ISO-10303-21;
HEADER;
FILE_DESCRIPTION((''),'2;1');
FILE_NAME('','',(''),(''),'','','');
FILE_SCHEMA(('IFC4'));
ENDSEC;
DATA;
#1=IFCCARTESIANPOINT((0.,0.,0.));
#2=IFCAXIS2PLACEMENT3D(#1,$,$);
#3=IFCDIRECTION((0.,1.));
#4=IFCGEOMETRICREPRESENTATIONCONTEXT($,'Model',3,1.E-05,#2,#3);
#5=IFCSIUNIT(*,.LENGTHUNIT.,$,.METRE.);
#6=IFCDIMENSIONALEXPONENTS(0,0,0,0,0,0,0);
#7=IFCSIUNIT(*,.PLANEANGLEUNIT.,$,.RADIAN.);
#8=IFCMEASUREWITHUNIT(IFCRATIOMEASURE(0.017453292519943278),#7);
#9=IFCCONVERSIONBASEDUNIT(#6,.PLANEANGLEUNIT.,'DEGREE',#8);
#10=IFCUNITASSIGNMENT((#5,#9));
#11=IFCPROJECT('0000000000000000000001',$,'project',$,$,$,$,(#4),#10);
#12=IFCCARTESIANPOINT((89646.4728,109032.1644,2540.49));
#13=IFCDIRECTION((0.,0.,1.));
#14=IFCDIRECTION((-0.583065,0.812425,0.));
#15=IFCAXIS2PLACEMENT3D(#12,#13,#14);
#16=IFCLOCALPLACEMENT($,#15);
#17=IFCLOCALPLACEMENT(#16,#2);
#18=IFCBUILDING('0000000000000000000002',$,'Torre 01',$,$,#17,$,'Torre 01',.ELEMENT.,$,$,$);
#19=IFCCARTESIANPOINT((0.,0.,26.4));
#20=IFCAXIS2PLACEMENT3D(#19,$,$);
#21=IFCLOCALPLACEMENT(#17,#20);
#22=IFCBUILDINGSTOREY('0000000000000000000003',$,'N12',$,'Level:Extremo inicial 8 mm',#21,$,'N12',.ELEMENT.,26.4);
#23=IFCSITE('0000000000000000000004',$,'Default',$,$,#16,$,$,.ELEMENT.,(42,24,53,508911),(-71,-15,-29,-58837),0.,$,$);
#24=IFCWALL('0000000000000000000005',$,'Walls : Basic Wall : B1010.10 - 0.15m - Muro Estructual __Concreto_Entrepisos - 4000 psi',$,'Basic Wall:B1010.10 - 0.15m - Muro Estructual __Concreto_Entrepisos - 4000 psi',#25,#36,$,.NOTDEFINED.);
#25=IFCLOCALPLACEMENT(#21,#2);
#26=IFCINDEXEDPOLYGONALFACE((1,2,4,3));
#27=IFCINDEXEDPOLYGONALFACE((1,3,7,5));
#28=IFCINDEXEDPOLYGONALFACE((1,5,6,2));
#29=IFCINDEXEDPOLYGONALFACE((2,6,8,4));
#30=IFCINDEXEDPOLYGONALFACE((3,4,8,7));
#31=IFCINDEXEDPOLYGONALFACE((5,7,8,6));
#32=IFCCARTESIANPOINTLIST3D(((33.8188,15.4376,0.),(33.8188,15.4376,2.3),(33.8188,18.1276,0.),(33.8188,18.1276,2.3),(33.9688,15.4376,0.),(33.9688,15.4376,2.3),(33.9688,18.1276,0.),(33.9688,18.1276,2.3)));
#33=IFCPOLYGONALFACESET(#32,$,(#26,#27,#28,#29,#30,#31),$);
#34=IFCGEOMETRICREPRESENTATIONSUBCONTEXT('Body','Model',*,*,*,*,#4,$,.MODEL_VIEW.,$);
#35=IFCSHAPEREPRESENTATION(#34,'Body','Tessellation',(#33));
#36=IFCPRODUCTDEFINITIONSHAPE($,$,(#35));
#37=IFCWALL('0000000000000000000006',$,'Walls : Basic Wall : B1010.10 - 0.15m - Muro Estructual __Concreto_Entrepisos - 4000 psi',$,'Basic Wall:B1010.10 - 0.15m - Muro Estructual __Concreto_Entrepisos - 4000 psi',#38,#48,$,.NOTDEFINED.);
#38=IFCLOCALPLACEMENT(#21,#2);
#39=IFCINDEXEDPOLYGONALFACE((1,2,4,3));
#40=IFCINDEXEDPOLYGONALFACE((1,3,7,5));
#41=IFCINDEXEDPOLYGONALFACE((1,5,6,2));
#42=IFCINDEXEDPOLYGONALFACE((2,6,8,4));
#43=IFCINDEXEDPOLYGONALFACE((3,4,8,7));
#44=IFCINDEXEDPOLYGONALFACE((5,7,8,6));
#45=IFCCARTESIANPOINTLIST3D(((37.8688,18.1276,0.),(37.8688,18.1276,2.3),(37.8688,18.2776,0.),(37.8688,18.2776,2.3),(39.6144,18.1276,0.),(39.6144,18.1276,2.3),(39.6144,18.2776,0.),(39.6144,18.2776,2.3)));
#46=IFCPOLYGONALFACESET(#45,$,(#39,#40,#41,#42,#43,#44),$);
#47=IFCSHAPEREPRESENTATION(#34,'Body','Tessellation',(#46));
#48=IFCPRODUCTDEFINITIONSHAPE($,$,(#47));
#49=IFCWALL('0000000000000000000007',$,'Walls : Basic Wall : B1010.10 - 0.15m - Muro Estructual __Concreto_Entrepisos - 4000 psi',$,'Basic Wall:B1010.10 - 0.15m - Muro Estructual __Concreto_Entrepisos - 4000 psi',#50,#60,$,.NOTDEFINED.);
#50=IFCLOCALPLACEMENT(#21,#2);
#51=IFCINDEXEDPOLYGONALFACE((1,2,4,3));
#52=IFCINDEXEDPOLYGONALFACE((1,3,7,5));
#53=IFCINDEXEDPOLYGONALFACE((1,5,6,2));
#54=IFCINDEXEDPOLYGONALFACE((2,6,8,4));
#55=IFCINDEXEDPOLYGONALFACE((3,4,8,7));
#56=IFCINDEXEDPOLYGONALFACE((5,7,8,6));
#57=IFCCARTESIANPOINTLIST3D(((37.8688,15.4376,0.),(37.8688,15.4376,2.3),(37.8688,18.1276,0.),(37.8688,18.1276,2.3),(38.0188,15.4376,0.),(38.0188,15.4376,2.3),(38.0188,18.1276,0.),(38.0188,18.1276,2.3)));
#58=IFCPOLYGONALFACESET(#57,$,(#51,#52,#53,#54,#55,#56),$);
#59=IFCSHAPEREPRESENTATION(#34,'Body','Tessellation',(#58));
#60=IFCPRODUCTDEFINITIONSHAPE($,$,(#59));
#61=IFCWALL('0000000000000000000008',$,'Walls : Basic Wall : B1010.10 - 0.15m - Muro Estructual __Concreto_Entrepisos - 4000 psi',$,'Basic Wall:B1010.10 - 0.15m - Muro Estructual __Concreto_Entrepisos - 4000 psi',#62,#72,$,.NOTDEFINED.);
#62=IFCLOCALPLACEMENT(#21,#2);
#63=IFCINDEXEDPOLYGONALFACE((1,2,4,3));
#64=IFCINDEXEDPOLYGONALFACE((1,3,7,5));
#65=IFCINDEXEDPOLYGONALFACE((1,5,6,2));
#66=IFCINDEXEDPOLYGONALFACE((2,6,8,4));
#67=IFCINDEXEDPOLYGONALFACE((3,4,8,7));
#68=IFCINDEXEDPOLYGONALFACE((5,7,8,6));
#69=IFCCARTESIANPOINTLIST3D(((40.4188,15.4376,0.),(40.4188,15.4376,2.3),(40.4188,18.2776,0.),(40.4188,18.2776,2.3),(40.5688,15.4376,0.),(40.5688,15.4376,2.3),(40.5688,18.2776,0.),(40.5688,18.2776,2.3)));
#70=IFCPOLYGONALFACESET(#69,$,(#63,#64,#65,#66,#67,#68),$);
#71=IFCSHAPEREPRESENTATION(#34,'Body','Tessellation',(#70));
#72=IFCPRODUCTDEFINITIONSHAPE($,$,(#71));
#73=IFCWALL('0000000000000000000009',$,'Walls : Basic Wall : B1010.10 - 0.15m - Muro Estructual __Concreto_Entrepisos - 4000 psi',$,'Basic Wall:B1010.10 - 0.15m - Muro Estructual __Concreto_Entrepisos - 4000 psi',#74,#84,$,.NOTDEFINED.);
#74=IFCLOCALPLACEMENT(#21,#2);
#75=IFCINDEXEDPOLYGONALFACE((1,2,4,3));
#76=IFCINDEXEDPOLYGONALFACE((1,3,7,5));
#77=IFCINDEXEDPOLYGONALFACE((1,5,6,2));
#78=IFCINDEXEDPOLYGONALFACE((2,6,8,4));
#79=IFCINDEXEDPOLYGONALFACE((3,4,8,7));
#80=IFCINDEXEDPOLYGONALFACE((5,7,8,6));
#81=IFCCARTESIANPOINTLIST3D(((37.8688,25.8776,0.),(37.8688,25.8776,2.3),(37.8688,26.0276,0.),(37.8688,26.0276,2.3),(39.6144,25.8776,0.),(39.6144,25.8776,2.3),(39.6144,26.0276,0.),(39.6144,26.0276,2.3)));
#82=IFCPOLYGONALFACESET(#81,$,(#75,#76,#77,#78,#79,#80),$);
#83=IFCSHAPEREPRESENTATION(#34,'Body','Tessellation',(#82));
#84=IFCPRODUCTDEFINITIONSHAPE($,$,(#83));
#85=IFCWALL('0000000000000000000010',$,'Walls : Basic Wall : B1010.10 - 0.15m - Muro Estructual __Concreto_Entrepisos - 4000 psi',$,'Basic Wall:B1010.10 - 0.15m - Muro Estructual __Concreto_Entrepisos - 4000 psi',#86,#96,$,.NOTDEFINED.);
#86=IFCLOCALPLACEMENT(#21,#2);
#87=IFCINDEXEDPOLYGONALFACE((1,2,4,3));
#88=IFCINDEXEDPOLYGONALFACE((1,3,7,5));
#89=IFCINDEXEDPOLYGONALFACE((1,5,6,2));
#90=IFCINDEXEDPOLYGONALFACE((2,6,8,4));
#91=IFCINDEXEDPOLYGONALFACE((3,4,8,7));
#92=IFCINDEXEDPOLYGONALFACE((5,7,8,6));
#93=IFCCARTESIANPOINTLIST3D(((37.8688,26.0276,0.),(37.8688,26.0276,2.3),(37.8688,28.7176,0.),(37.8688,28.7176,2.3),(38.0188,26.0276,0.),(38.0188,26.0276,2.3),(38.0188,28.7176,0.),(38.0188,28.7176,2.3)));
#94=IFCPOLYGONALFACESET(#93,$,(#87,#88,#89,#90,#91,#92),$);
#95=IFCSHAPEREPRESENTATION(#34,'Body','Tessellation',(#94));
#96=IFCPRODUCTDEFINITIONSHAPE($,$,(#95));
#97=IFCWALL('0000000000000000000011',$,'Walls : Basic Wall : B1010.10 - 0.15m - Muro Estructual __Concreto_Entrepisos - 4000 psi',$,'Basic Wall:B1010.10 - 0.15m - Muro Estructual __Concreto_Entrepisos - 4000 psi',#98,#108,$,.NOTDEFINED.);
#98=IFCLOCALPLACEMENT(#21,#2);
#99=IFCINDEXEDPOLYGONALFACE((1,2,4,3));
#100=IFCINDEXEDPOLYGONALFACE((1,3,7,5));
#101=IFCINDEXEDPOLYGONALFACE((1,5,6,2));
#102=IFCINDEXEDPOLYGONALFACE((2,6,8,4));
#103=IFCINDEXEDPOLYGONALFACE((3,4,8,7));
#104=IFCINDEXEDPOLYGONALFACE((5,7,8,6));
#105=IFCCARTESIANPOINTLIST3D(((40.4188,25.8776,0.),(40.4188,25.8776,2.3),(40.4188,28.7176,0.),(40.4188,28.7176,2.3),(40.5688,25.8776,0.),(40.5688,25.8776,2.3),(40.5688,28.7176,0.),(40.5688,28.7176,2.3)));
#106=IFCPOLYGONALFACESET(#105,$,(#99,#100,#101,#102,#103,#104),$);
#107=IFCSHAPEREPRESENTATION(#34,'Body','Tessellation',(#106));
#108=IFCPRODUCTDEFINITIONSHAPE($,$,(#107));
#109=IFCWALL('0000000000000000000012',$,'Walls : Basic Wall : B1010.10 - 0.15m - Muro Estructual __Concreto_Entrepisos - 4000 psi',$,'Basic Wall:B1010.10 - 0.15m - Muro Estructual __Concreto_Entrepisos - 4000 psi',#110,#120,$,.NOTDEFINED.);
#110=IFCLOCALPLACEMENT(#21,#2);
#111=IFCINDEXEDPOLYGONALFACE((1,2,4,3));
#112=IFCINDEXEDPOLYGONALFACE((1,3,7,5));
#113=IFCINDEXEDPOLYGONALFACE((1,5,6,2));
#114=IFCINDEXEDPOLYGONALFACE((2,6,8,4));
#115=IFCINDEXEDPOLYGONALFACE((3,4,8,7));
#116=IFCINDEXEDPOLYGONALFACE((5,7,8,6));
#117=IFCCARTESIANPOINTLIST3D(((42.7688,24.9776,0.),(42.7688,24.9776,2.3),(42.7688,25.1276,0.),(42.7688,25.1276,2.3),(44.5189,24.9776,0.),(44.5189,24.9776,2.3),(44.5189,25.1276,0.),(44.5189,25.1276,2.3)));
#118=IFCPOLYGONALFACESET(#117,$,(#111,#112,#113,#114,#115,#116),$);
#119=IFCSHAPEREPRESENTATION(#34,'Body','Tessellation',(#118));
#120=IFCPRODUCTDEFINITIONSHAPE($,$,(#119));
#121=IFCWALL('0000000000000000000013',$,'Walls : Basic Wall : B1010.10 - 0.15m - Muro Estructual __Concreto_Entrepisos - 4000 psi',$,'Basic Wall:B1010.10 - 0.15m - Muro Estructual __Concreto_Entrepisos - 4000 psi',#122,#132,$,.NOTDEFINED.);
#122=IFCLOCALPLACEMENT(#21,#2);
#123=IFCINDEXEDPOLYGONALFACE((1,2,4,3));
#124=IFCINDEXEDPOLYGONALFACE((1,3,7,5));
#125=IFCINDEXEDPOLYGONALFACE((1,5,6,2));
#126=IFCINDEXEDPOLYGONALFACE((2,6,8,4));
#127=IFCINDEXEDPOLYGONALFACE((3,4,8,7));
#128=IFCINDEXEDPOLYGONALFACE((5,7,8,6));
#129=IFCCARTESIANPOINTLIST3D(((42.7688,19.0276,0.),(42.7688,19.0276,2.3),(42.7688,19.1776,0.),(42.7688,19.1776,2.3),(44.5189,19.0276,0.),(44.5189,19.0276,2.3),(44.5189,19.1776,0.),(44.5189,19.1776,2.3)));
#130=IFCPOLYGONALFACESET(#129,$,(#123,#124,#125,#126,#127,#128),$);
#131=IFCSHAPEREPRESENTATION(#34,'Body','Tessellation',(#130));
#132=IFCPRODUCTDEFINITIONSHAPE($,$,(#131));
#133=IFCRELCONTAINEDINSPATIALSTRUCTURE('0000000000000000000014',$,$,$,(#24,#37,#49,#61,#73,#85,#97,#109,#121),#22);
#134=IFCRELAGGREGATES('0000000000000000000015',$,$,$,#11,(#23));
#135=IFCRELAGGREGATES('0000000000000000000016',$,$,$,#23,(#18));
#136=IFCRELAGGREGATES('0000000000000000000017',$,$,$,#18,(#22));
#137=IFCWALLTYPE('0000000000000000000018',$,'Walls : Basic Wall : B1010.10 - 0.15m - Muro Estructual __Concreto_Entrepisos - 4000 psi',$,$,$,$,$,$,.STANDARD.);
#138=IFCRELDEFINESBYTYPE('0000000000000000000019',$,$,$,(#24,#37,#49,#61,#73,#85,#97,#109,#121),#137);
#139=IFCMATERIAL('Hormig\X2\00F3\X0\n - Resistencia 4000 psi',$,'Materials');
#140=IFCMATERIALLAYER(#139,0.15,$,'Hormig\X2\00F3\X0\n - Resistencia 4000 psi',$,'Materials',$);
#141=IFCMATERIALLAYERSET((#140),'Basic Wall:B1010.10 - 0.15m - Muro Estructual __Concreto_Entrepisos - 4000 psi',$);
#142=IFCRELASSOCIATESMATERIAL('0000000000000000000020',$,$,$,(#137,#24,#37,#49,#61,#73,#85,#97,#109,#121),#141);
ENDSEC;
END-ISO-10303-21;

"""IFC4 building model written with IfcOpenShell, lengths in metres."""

from ifc_helpers import new_model, entity, si_unit, converted_unit, direction, frame, frame_2d, origin, place, context, subcontext, project, spatial, rectangle, extrude, material, layer, layer_set, layer_usage, type_object, element, save


model = new_model("IFC4")

# Units and contexts
model_context = context("Model", 3, precision=1e-05, world=origin(), true_north=direction((0.0, 1.0)))
body_context = subcontext(model_context, "Body", "Model", "MODEL_VIEW")
ifc_project = project(units=[si_unit("LENGTHUNIT", "METRE"), converted_unit("PLANEANGLEUNIT", "DEGREE", entity("IfcRatioMeasure", 0.017453292519943278), si_unit("PLANEANGLEUNIT", "RADIAN"), dimensions=[0, 0, 0, 0, 0, 0, 0])], contexts=[model_context])

# Site, building, storey
site_placement = place(None, frame((89646.4728, 109032.1644, 2540.49), z_axis=(0.0, 0.0, 1.0), x_axis=(-0.583065, 0.812425, 0.0)))
site = spatial("IfcSite", under=ifc_project, at=site_placement, Name="Default", CompositionType="ELEMENT", RefLatitude=(42, 24, 53, 508911), RefLongitude=(-71, -15, -29, -58837), RefElevation=0.0)
building_placement = place(site_placement, origin())
building = spatial("IfcBuilding", under=site, at=building_placement, Name="Torre 01", LongName="Torre 01", CompositionType="ELEMENT")
storey_placement = place(building_placement, frame((0.0, 0.0, 26.4)))
storey = spatial("IfcBuildingStorey", under=building, at=storey_placement, Name="N12", ObjectType="Level:Extremo inicial 8 mm", LongName="N12", CompositionType="ELEMENT", Elevation=26.4)

# Walls
ifc_material = material(Name="Hormigón - Resistencia 4000 psi", Category="Materials")
ifc_layer_1 = layer(ifc_material, 0.15, Name="Hormigón - Resistencia 4000 psi", Category="Materials")
ifc_layer_set_1 = layer_set([ifc_layer_1], Name="Basic Wall:B1010.10 - 0.15m - Muro Estructual __Concreto_Entrepisos - 4000 psi")
wall_type_1 = type_object("IfcWallType", Name="Walls : Basic Wall : B1010.10 - 0.15m - Muro Estructual __Concreto_Entrepisos - 4000 psi", PredefinedType="STANDARD", material=ifc_layer_set_1)
ifc_layer_usage_1 = layer_usage(ifc_layer_set_1, "AXIS2", "NEGATIVE", 0.075)
wall_1_placement = place(storey_placement, frame((33.8938, 18.1276, 0.0), z_axis=(0.0, 0.0, 1.0), x_axis=(0.0, -1.0, 0.0)))
element("IfcWall", 1, at=wall_1_placement, inside=storey, type_object=wall_type_1, material=ifc_layer_usage_1, Name="Walls : Basic Wall : B1010.10 - 0.15m - Muro Estructual __Concreto_Entrepisos - 4000 psi", ObjectType="Basic Wall:B1010.10 - 0.15m - Muro Estructual __Concreto_Entrepisos - 4000 psi", PredefinedType="NOTDEFINED", context=body_context, shape_type="SweptSolid", body=[
    extrude(rectangle(XDim=2.69, YDim=0.15, at=frame_2d((1.345, 0.0), x_axis=(-1.0, 0.0))), origin(), (0.0, 0.0, 1.0), 2.3),
])
ifc_layer_usage_2 = layer_usage(ifc_layer_set_1, "AXIS2", "NEGATIVE", 0.075)
wall_2_placement = place(storey_placement, frame((39.6144, 18.2026, 0.0), z_axis=(0.0, 0.0, 1.0), x_axis=(-1.0, 0.0, 0.0)))
element("IfcWall", 2, at=wall_2_placement, inside=storey, type_object=wall_type_1, material=ifc_layer_usage_2, Name="Walls : Basic Wall : B1010.10 - 0.15m - Muro Estructual __Concreto_Entrepisos - 4000 psi", ObjectType="Basic Wall:B1010.10 - 0.15m - Muro Estructual __Concreto_Entrepisos - 4000 psi", PredefinedType="NOTDEFINED", context=body_context, shape_type="SweptSolid", body=[
    extrude(rectangle(XDim=1.7455, YDim=0.15, at=frame_2d((0.8728, 0.0), x_axis=(-1.0, 0.0))), origin(), (0.0, 0.0, 1.0), 2.3),
])
ifc_layer_usage_3 = layer_usage(ifc_layer_set_1, "AXIS2", "NEGATIVE", 0.075)
wall_3_placement = place(storey_placement, frame((37.9438, 18.1276, 0.0), z_axis=(0.0, 0.0, 1.0), x_axis=(0.0, -1.0, 0.0)))
element("IfcWall", 3, at=wall_3_placement, inside=storey, type_object=wall_type_1, material=ifc_layer_usage_3, Name="Walls : Basic Wall : B1010.10 - 0.15m - Muro Estructual __Concreto_Entrepisos - 4000 psi", ObjectType="Basic Wall:B1010.10 - 0.15m - Muro Estructual __Concreto_Entrepisos - 4000 psi", PredefinedType="NOTDEFINED", context=body_context, shape_type="SweptSolid", body=[
    extrude(rectangle(XDim=2.69, YDim=0.15, at=frame_2d((1.345, 0.0), x_axis=(-1.0, 0.0))), origin(), (0.0, 0.0, 1.0), 2.3),
])
ifc_layer_usage_4 = layer_usage(ifc_layer_set_1, "AXIS2", "NEGATIVE", 0.075)
wall_4_placement = place(storey_placement, frame((40.4938, 18.2776, 0.0), z_axis=(0.0, 0.0, 1.0), x_axis=(0.0, -1.0, 0.0)))
element("IfcWall", 4, at=wall_4_placement, inside=storey, type_object=wall_type_1, material=ifc_layer_usage_4, Name="Walls : Basic Wall : B1010.10 - 0.15m - Muro Estructual __Concreto_Entrepisos - 4000 psi", ObjectType="Basic Wall:B1010.10 - 0.15m - Muro Estructual __Concreto_Entrepisos - 4000 psi", PredefinedType="NOTDEFINED", context=body_context, shape_type="SweptSolid", body=[
    extrude(rectangle(XDim=2.84, YDim=0.15, at=frame_2d((1.42, 0.0), x_axis=(-1.0, 0.0))), origin(), (0.0, 0.0, 1.0), 2.3),
])
ifc_layer_usage_5 = layer_usage(ifc_layer_set_1, "AXIS2", "POSITIVE", -0.075)
wall_5_placement = place(storey_placement, frame((39.6144, 25.9526, 0.0), z_axis=(0.0, 0.0, 1.0), x_axis=(-1.0, 0.0, 0.0)))
element("IfcWall", 5, at=wall_5_placement, inside=storey, type_object=wall_type_1, material=ifc_layer_usage_5, Name="Walls : Basic Wall : B1010.10 - 0.15m - Muro Estructual __Concreto_Entrepisos - 4000 psi", ObjectType="Basic Wall:B1010.10 - 0.15m - Muro Estructual __Concreto_Entrepisos - 4000 psi", PredefinedType="NOTDEFINED", context=body_context, shape_type="SweptSolid", body=[
    extrude(rectangle(XDim=1.7455, YDim=0.15, at=frame_2d((0.8728, 0.0), x_axis=(-1.0, 0.0))), origin(), (0.0, 0.0, 1.0), 2.3),
])
ifc_layer_usage_6 = layer_usage(ifc_layer_set_1, "AXIS2", "POSITIVE", -0.075)
wall_6_placement = place(storey_placement, frame((37.9438, 26.0276, 0.0), z_axis=(0.0, 0.0, 1.0), x_axis=(0.0, 1.0, 0.0)))
element("IfcWall", 6, at=wall_6_placement, inside=storey, type_object=wall_type_1, material=ifc_layer_usage_6, Name="Walls : Basic Wall : B1010.10 - 0.15m - Muro Estructual __Concreto_Entrepisos - 4000 psi", ObjectType="Basic Wall:B1010.10 - 0.15m - Muro Estructual __Concreto_Entrepisos - 4000 psi", PredefinedType="NOTDEFINED", context=body_context, shape_type="SweptSolid", body=[
    extrude(rectangle(XDim=2.69, YDim=0.15, at=frame_2d((1.345, 0.0), x_axis=(-1.0, 0.0))), origin(), (0.0, 0.0, 1.0), 2.3),
])
ifc_layer_usage_7 = layer_usage(ifc_layer_set_1, "AXIS2", "POSITIVE", -0.075)
wall_7_placement = place(storey_placement, frame((40.4938, 25.8776, 0.0), z_axis=(0.0, 0.0, 1.0), x_axis=(0.0, 1.0, 0.0)))
element("IfcWall", 7, at=wall_7_placement, inside=storey, type_object=wall_type_1, material=ifc_layer_usage_7, Name="Walls : Basic Wall : B1010.10 - 0.15m - Muro Estructual __Concreto_Entrepisos - 4000 psi", ObjectType="Basic Wall:B1010.10 - 0.15m - Muro Estructual __Concreto_Entrepisos - 4000 psi", PredefinedType="NOTDEFINED", context=body_context, shape_type="SweptSolid", body=[
    extrude(rectangle(XDim=2.84, YDim=0.15, at=frame_2d((1.42, 0.0), x_axis=(-1.0, 0.0))), origin(), (0.0, 0.0, 1.0), 2.3),
])
ifc_layer_usage_8 = layer_usage(ifc_layer_set_1, "AXIS2", "NEGATIVE", 0.075)
wall_8_placement = place(storey_placement, frame((42.7688, 25.0526, 0.0)))
element("IfcWall", 8, at=wall_8_placement, inside=storey, type_object=wall_type_1, material=ifc_layer_usage_8, Name="Walls : Basic Wall : B1010.10 - 0.15m - Muro Estructual __Concreto_Entrepisos - 4000 psi", ObjectType="Basic Wall:B1010.10 - 0.15m - Muro Estructual __Concreto_Entrepisos - 4000 psi", PredefinedType="NOTDEFINED", context=body_context, shape_type="SweptSolid", body=[
    extrude(rectangle(XDim=1.75, YDim=0.15, at=frame_2d((0.875, 0.0), x_axis=(-1.0, 0.0))), origin(), (0.0, 0.0, 1.0), 2.3),
])
ifc_layer_usage_9 = layer_usage(ifc_layer_set_1, "AXIS2", "POSITIVE", -0.075)
wall_9_placement = place(storey_placement, frame((42.7688, 19.1026, 0.0)))
element("IfcWall", 9, at=wall_9_placement, inside=storey, type_object=wall_type_1, material=ifc_layer_usage_9, Name="Walls : Basic Wall : B1010.10 - 0.15m - Muro Estructual __Concreto_Entrepisos - 4000 psi", ObjectType="Basic Wall:B1010.10 - 0.15m - Muro Estructual __Concreto_Entrepisos - 4000 psi", PredefinedType="NOTDEFINED", context=body_context, shape_type="SweptSolid", body=[
    extrude(rectangle(XDim=1.75, YDim=0.15, at=frame_2d((0.875, 0.0), x_axis=(-1.0, 0.0))), origin(), (0.0, 0.0, 1.0), 2.3),
])

save(model, "model.ifc")
